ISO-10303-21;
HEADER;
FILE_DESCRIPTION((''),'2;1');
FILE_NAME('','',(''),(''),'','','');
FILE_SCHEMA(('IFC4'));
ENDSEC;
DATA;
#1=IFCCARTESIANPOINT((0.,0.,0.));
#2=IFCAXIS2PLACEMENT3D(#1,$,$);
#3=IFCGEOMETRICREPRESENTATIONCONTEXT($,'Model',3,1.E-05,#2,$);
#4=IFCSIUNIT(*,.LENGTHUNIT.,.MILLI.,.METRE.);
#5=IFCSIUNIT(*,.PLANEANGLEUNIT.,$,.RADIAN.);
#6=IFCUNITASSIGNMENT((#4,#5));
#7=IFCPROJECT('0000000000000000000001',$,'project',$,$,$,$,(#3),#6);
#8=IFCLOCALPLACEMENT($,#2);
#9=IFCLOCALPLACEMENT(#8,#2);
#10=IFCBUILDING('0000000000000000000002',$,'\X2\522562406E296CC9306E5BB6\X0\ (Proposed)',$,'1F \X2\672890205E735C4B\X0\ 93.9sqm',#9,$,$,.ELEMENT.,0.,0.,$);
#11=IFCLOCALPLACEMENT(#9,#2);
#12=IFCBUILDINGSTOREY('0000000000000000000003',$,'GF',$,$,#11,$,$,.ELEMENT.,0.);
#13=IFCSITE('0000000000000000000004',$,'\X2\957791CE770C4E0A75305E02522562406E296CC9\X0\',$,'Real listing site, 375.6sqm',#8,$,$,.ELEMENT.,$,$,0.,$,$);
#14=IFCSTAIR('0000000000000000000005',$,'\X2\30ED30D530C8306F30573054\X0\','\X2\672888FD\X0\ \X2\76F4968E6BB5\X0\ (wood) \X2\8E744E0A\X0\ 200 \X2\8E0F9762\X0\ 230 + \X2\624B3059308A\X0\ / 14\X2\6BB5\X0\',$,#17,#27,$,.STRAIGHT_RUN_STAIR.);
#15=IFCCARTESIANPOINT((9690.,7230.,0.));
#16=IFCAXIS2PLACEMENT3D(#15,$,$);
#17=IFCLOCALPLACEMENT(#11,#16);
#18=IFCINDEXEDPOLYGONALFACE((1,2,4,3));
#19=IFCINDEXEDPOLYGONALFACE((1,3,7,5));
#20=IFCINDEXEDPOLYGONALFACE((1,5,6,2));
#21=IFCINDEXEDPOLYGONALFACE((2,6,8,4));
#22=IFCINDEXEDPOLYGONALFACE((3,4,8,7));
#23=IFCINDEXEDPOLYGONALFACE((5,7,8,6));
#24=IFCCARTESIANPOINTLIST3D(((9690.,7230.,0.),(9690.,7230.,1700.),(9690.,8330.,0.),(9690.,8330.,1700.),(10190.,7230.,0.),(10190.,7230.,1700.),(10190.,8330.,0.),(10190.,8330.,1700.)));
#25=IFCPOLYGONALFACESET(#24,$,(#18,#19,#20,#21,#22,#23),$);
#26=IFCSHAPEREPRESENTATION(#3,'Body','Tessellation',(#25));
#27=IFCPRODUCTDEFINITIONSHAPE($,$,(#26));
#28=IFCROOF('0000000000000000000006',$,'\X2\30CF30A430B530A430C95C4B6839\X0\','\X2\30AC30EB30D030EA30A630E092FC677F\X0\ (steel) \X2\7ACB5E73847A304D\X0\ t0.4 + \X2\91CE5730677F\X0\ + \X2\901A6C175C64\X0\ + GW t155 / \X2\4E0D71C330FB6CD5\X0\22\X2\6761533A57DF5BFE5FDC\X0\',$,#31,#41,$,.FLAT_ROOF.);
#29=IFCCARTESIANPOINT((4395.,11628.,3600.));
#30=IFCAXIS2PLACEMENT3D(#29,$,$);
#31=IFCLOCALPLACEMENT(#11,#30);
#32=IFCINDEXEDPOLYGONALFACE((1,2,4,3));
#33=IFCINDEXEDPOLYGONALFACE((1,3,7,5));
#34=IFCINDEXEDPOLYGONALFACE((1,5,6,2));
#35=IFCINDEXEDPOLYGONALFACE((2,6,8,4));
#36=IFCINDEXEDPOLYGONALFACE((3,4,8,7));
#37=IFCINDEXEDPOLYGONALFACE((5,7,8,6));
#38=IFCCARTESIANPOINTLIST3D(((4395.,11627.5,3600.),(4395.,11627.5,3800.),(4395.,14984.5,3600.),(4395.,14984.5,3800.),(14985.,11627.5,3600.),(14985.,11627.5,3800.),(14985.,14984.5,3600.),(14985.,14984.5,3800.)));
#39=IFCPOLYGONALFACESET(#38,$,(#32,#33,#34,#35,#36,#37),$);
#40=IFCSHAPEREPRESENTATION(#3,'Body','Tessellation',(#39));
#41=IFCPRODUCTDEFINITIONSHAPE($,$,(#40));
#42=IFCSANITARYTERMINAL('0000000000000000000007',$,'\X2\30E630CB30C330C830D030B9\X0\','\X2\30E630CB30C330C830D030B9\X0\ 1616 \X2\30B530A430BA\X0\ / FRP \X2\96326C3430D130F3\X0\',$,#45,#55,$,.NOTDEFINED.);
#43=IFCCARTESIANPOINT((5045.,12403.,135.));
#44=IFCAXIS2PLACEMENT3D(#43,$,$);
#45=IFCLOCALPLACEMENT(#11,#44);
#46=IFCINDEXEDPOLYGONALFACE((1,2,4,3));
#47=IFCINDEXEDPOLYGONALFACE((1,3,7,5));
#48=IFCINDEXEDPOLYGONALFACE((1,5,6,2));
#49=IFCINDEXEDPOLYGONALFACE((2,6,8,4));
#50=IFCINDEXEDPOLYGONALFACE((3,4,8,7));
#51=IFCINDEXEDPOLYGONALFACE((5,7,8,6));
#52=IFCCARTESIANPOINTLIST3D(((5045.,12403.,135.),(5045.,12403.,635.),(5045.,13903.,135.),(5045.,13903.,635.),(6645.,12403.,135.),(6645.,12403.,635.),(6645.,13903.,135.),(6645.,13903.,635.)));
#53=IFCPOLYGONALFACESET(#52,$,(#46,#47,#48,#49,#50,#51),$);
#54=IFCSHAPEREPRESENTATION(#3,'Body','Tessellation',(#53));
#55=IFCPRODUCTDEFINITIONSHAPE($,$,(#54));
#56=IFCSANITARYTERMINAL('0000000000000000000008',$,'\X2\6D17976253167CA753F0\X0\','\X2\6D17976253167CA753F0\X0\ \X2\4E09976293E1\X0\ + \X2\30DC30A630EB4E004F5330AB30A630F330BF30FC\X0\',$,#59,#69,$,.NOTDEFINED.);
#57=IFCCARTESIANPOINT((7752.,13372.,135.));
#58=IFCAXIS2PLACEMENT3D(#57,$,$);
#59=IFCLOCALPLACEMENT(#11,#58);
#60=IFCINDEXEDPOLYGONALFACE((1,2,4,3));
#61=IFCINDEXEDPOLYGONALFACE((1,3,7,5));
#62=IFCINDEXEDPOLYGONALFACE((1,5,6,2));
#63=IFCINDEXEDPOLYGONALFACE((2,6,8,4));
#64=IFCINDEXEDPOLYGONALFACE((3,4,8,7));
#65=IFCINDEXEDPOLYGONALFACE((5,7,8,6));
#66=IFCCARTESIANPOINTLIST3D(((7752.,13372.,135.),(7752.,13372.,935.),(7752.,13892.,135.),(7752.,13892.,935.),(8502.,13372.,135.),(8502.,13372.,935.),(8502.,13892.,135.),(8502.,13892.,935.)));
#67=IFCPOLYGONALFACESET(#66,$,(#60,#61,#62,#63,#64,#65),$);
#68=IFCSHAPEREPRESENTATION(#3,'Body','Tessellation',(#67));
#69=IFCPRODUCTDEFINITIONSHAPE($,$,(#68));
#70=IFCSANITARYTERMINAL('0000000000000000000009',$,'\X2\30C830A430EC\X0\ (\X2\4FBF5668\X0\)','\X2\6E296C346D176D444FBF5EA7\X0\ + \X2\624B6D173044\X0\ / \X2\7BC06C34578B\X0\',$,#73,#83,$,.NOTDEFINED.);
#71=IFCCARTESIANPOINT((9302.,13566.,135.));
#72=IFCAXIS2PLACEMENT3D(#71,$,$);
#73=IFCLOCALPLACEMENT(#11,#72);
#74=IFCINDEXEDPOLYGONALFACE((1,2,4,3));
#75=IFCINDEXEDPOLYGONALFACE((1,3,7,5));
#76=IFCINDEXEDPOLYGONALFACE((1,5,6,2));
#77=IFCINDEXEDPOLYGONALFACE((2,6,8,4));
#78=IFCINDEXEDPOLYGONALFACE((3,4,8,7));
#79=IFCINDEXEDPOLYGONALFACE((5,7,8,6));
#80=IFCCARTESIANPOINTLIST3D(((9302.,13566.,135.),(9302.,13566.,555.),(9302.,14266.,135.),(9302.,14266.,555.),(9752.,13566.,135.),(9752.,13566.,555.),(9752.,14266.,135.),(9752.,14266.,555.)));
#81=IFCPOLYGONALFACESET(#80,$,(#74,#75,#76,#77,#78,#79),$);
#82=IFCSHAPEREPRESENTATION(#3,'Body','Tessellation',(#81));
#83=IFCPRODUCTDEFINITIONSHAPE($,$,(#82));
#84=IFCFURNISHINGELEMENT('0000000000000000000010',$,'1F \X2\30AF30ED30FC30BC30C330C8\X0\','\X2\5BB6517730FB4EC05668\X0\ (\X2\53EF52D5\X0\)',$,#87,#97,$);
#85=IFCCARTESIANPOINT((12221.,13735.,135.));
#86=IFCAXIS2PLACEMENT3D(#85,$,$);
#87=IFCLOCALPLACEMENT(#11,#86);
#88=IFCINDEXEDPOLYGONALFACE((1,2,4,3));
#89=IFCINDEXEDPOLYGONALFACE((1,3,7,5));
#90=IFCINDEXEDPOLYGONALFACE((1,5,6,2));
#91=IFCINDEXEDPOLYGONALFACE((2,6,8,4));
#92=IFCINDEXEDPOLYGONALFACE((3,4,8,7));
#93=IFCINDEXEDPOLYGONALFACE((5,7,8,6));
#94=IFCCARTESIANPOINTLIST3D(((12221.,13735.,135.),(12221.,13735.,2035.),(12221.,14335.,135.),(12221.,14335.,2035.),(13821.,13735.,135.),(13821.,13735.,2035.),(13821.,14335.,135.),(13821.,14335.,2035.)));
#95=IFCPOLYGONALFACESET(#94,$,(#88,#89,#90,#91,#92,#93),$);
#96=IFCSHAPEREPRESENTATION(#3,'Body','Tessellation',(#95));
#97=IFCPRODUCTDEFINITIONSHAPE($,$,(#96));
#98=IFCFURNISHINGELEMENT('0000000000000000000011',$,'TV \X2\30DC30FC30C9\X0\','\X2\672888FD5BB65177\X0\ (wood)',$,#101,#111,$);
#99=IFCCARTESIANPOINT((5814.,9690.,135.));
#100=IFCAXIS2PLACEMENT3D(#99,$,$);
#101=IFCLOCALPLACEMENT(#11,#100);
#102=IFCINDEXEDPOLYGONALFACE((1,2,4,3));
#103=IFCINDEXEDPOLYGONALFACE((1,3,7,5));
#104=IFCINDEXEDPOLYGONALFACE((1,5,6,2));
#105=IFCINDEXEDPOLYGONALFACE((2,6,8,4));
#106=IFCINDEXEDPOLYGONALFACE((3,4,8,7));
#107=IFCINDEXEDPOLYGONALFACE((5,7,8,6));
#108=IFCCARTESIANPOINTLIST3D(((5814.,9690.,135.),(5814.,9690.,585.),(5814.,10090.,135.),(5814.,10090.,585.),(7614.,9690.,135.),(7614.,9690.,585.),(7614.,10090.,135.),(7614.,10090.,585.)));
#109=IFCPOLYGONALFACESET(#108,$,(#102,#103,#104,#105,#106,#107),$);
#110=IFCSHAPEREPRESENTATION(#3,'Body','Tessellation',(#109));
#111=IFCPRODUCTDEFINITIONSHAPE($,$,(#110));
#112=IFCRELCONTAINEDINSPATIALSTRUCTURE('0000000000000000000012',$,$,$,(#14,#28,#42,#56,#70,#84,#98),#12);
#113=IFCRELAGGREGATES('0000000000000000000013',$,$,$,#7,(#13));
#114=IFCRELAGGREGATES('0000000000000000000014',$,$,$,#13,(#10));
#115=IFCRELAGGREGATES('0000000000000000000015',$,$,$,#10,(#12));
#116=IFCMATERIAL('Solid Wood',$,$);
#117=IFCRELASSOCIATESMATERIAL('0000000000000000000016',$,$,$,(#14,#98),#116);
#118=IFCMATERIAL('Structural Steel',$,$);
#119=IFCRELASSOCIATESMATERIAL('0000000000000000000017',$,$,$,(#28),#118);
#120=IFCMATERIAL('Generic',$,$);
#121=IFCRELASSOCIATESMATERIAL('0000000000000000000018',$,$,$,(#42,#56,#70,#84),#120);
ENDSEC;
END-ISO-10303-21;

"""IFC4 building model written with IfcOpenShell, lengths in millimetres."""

from ifc_helpers import new_model, si_unit, frame, frame_2d, origin, place, context, project, spatial, rectangle, extrude, material, element, save


model = new_model("IFC4")

# Units and contexts
model_context = context("Model", 3, precision=1e-05, world=origin())
ifc_project = project(units=[si_unit("LENGTHUNIT", "METRE", prefix="MILLI"), si_unit("PLANEANGLEUNIT", "RADIAN")], contexts=[model_context])

# Site, building, storey
site_placement = place(None, origin())
site = spatial("IfcSite", under=ifc_project, at=site_placement, Name="長野県上田市別所温泉", ObjectType="Real listing site, 375.6sqm", CompositionType="ELEMENT", RefElevation=0.0)
building_placement = place(site_placement, origin())
building = spatial("IfcBuilding", under=site, at=building_placement, Name="別所温泉の家 (Proposed)", ObjectType="1F 木造平屋 93.9sqm", CompositionType="ELEMENT", ElevationOfRefHeight=0.0, ElevationOfTerrain=0.0)
storey_placement = place(building_placement, origin())
storey = spatial("IfcBuildingStorey", under=building, at=storey_placement, Name="GF", CompositionType="ELEMENT", Elevation=0.0)

# Shared definitions
ifc_material_1 = material(Name="Solid Wood")

# Stair
stair_placement = place(storey_placement, frame((9690.0, 7230.0, 0.0)))
element("IfcStair", 1, at=stair_placement, inside=storey, material=ifc_material_1, Name="ロフトはしご", Description="木製 直階段 (wood) 蹴上 200 踏面 230 + 手すり / 14段", PredefinedType="STRAIGHT_RUN_STAIR", context=model_context, shape_type="SweptSolid", body=[
    extrude(rectangle(XDim=500.0, YDim=1100.0, at=frame_2d((250.0, 550.0))), frame((9690.0, 7230.0, 0.0)), (0.0, 0.0, 1.0), 1700.0),
])

# Roof
ifc_material_2 = material(Name="Structural Steel")
roof_placement = place(storey_placement, frame((4395.0, 11628.0, 3600.0)))
element("IfcRoof", 2, at=roof_placement, inside=storey, material=ifc_material_2, Name="ハイサイド屋根", Description="ガルバリウム鋼板 (steel) 立平葺き t0.4 + 野地板 + 通気層 + GW t155 / 不燃・法22条区域対応", PredefinedType="FLAT_ROOF", context=model_context, shape_type="SweptSolid", body=[
    extrude(rectangle(XDim=10590.0, YDim=3357.0, at=frame_2d((5295.0, 1678.0))), frame((4395.0, 11628.0, 3600.0)), (0.0, 0.0, 1.0), 200.0),
])

# Sanitary terminals
ifc_material_3 = material(Name="Generic")
sanitary_terminal_1_placement = place(storey_placement, frame((5045.0, 12403.0, 135.0)))
element("IfcSanitaryTerminal", 3, at=sanitary_terminal_1_placement, inside=storey, material=ifc_material_3, Name="ユニットバス", Description="ユニットバス 1616 サイズ / FRP 防水パン", PredefinedType="NOTDEFINED", context=model_context, shape_type="SweptSolid", body=[
    extrude(rectangle(XDim=1600.0, YDim=1500.0, at=frame_2d((800.0, 750.0))), frame((5045.0, 12403.0, 135.0)), (0.0, 0.0, 1.0), 500.0),
])
sanitary_terminal_2_placement = place(storey_placement, frame((7752.0, 13372.0, 135.0)))
element("IfcSanitaryTerminal", 4, at=sanitary_terminal_2_placement, inside=storey, material=ifc_material_3, Name="洗面化粧台", Description="洗面化粧台 三面鏡 + ボウル一体カウンター", PredefinedType="NOTDEFINED", context=model_context, shape_type="SweptSolid", body=[
    extrude(rectangle(XDim=750.0, YDim=520.0, at=frame_2d((375.0, 260.0))), frame((7752.0, 13372.0, 135.0)), (0.0, 0.0, 1.0), 800.0),
])
sanitary_terminal_3_placement = place(storey_placement, frame((9302.0, 13566.0, 135.0)))
element("IfcSanitaryTerminal", 5, at=sanitary_terminal_3_placement, inside=storey, material=ifc_material_3, Name="トイレ (便器)", Description="温水洗浄便座 + 手洗い / 節水型", PredefinedType="NOTDEFINED", context=model_context, shape_type="SweptSolid", body=[
    extrude(rectangle(XDim=450.0, YDim=700.0, at=frame_2d((225.0, 350.0))), frame((9302.0, 13566.0, 135.0)), (0.0, 0.0, 1.0), 420.0),
])

# Furnishing elements
furnishing_1_placement = place(storey_placement, frame((12221.0, 13735.0, 135.0)))
element("IfcFurnishingElement", 6, at=furnishing_1_placement, inside=storey, material=ifc_material_3, Name="1F クローゼット", Description="家具・什器 (可動)", context=model_context, shape_type="SweptSolid", body=[
    extrude(rectangle(XDim=1600.0, YDim=600.0, at=frame_2d((800.0, 300.0))), frame((12221.0, 13735.0, 135.0)), (0.0, 0.0, 1.0), 1900.0),
])
furnishing_2_placement = place(storey_placement, frame((5814.0, 9690.0, 135.0)))
element("IfcFurnishingElement", 7, at=furnishing_2_placement, inside=storey, material=ifc_material_1, Name="TV ボード", Description="木製家具 (wood)", context=model_context, shape_type="SweptSolid", body=[
    extrude(rectangle(XDim=1800.0, YDim=400.0, at=frame_2d((900.0, 200.0))), frame((5814.0, 9690.0, 135.0)), (0.0, 0.0, 1.0), 450.0),
])

save(model, "model.ifc")
